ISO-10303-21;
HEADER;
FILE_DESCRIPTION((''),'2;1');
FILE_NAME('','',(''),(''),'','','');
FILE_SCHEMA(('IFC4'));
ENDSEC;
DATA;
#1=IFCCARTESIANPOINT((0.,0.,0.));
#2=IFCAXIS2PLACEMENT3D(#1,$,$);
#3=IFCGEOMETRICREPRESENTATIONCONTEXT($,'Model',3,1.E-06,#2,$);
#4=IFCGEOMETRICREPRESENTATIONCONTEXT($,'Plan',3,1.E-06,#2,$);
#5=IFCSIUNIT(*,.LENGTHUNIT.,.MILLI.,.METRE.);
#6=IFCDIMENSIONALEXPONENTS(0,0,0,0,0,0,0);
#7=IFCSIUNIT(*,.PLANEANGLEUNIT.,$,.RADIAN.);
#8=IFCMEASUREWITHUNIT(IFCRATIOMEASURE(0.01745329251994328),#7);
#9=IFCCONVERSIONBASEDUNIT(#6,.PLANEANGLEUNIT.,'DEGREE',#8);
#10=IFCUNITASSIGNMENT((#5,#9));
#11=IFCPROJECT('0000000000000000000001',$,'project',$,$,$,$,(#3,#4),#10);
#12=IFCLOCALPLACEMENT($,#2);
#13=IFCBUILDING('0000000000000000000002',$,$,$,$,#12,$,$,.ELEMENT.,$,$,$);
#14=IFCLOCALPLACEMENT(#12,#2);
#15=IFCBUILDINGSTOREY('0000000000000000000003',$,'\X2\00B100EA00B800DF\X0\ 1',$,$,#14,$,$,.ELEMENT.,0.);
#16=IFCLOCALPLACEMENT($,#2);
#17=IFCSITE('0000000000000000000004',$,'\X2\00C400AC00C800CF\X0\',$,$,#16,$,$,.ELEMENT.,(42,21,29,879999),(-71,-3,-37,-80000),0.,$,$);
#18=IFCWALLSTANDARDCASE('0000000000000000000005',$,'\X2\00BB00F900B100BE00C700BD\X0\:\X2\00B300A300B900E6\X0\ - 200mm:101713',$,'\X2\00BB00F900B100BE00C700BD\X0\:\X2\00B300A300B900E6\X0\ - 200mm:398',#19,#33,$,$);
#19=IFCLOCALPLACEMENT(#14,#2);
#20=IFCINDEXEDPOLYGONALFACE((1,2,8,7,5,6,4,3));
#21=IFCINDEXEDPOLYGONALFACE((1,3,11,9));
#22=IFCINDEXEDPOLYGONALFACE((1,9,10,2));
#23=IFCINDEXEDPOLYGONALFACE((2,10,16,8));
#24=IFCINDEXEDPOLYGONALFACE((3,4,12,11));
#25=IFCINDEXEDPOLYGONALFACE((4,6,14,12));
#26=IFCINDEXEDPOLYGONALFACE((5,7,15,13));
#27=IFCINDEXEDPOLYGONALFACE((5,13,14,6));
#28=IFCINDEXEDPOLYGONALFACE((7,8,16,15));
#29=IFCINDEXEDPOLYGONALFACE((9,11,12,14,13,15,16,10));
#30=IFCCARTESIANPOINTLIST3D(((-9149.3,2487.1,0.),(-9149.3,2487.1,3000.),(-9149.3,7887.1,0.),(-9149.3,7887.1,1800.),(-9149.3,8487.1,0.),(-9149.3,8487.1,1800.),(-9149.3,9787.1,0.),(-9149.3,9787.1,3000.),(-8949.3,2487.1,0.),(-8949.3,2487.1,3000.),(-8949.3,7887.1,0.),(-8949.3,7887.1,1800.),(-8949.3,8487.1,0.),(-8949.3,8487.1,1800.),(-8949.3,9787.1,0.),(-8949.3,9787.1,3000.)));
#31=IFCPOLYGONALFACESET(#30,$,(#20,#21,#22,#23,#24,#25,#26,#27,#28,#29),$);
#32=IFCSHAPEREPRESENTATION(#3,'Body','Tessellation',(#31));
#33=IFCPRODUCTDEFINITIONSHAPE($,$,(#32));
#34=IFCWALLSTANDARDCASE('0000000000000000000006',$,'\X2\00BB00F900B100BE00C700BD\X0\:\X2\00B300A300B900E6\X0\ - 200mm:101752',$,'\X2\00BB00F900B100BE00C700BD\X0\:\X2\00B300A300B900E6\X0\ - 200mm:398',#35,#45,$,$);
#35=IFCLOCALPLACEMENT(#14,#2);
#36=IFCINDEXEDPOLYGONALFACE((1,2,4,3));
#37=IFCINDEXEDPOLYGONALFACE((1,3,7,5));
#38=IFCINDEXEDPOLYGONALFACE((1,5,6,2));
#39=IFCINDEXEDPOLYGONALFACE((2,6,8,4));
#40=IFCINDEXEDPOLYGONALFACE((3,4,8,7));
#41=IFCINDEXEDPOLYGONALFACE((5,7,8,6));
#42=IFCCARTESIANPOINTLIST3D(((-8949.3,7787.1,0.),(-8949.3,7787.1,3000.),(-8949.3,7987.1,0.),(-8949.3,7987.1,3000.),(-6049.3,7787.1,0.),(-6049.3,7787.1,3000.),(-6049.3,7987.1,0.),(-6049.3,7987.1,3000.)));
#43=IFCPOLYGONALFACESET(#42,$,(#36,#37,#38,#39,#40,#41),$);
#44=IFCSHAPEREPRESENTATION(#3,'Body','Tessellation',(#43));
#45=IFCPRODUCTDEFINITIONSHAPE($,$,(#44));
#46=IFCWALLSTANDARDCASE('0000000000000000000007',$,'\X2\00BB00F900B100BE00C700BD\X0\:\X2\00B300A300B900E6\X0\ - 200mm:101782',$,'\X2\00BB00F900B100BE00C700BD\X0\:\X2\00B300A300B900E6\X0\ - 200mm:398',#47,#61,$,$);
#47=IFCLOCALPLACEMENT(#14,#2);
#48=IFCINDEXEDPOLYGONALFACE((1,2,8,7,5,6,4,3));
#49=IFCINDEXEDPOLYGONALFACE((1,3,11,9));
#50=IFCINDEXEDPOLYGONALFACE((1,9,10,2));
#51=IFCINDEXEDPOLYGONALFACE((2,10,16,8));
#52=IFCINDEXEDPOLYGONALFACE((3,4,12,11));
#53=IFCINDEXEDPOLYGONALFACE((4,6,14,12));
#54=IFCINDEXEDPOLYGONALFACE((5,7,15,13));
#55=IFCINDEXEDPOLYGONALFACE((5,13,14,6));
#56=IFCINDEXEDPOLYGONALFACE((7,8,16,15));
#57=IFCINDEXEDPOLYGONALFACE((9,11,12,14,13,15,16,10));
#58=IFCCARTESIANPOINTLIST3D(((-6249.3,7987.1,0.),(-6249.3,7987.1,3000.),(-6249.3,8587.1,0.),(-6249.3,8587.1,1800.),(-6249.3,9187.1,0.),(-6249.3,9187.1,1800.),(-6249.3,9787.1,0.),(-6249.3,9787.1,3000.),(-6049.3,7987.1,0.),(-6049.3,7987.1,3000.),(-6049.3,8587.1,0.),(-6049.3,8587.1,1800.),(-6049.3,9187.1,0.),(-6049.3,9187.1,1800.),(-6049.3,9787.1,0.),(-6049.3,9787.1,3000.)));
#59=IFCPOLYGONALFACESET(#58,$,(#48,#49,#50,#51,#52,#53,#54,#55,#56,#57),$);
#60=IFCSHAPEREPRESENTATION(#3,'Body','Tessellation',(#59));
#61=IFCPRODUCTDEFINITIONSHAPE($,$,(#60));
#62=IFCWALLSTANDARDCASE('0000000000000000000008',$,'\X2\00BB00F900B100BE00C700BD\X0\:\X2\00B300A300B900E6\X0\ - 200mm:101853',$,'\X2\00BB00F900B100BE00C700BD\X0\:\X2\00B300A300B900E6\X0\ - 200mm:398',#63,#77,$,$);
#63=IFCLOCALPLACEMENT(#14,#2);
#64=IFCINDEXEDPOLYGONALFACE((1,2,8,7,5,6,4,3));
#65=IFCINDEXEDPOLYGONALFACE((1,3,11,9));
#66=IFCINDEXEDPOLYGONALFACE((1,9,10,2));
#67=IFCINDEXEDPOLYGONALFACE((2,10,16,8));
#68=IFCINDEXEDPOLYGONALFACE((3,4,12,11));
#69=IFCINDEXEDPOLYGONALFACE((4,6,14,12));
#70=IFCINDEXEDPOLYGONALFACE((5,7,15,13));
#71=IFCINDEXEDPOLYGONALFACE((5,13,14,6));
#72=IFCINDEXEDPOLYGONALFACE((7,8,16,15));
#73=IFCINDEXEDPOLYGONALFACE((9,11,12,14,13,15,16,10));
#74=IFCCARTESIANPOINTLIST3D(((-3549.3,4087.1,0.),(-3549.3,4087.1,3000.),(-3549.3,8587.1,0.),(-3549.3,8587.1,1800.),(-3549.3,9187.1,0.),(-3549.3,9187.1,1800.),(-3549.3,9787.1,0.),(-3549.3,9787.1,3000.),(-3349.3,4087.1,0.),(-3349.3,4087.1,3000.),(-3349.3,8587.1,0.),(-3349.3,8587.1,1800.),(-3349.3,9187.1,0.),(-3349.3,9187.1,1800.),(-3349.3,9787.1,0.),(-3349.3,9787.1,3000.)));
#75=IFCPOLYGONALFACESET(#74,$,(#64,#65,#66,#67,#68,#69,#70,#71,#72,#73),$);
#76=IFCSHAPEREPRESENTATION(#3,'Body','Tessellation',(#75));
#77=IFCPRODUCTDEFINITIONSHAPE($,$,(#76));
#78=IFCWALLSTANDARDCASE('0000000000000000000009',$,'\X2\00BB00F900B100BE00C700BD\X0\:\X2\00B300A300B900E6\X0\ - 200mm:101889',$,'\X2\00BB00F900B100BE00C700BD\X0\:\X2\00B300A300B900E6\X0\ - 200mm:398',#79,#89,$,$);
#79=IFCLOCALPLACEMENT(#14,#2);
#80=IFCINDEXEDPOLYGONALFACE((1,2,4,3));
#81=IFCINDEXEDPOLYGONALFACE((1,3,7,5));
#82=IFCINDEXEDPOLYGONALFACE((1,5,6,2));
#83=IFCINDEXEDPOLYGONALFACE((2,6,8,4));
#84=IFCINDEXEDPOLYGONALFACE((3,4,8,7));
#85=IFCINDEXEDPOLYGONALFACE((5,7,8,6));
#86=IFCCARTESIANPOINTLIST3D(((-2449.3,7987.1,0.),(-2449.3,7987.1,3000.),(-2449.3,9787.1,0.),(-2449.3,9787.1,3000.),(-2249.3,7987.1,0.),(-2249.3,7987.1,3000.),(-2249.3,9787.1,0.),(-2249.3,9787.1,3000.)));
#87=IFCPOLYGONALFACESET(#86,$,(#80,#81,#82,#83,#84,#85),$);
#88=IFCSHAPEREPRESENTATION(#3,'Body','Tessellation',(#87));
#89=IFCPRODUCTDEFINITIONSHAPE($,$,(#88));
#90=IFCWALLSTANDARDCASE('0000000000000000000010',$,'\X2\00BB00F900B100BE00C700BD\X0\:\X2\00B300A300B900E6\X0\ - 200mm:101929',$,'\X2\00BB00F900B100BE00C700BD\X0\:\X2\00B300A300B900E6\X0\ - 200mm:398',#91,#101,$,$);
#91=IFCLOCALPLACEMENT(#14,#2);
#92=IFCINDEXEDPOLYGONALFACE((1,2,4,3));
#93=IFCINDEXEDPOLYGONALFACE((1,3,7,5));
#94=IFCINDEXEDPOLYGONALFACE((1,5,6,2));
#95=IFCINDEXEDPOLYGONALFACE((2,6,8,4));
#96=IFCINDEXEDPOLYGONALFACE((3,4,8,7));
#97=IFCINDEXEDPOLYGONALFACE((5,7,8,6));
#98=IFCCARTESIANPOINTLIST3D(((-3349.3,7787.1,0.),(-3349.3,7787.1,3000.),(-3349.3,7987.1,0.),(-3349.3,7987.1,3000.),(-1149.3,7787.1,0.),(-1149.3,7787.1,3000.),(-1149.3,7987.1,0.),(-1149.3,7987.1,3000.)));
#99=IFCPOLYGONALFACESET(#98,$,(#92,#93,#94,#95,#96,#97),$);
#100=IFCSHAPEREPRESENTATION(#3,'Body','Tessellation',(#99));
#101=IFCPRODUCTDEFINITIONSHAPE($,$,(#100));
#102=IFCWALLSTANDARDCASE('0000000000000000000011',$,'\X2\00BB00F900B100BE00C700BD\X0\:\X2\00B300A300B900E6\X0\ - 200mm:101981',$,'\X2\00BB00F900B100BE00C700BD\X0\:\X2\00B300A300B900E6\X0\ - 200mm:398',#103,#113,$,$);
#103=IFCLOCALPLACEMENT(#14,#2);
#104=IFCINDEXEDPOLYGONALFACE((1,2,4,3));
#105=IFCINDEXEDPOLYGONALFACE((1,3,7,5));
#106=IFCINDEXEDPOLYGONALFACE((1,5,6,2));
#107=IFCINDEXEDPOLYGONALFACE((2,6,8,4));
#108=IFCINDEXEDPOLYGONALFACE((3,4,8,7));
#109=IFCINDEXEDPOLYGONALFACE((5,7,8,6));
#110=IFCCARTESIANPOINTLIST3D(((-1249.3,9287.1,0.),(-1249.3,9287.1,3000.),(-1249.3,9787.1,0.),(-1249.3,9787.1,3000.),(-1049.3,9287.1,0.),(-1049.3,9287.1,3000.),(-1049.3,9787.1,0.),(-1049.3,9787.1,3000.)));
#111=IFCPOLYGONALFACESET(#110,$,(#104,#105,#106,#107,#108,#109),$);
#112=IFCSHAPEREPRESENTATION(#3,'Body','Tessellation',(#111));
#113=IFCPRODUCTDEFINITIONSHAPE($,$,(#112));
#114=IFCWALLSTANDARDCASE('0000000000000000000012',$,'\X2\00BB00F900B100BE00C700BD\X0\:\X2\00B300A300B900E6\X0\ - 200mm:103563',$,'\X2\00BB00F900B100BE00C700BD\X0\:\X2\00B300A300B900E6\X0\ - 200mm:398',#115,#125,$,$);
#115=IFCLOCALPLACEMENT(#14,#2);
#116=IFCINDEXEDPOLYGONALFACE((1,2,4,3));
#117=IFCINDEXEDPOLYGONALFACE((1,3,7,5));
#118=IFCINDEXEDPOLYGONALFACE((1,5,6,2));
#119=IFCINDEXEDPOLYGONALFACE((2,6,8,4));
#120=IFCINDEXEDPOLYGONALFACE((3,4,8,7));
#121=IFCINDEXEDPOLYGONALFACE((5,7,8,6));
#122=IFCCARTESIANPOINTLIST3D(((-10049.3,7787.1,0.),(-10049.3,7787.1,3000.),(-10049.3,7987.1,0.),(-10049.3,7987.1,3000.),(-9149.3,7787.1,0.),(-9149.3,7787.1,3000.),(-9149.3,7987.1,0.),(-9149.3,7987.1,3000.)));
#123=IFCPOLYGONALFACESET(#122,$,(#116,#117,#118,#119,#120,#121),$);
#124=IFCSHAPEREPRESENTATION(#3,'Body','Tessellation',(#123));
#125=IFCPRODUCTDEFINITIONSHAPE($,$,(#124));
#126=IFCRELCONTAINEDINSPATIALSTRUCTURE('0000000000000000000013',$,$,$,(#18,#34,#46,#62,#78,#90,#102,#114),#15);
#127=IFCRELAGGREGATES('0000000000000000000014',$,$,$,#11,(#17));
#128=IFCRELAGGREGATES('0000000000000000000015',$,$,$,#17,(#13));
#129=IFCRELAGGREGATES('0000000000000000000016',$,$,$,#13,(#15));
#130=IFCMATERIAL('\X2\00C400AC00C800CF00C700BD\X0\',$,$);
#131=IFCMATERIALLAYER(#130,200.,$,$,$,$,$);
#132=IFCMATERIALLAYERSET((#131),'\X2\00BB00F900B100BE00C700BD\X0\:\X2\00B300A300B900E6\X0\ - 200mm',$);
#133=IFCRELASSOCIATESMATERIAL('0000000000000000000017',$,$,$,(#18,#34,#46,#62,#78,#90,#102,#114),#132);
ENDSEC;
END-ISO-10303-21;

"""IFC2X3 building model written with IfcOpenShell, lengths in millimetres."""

from ifc_helpers import new_model, entity, si_unit, converted_unit, frame, frame_2d, origin, place, context, project, spatial, rectangle, extrude, material, layer, layer_set, layer_usage, element, save


model = new_model("IFC2X3")

# Units and contexts
model_context = context("Model", 3, precision=1e-06, world=origin())
plan_context = context("Plan", 3, precision=1e-06, world=origin())
ifc_project = project(units=[si_unit("LENGTHUNIT", "METRE", prefix="MILLI"), converted_unit("PLANEANGLEUNIT", "DEGREE", entity("IfcRatioMeasure", 0.01745329251994328), si_unit("PLANEANGLEUNIT", "RADIAN"), dimensions=[0, 0, 0, 0, 0, 0, 0])], contexts=[model_context, plan_context])

# Site, building, storey
site_placement = place(None, origin())
site = spatial("IfcSite", under=ifc_project, at=site_placement, Name="Ä¬ÈÏ", CompositionType="ELEMENT", RefLatitude=(42, 21, 29, 879999), RefLongitude=(-71, -3, -37, -80000), RefElevation=0.0)
building_placement = place(None, origin())
building = spatial("IfcBuilding", under=site, at=building_placement, CompositionType="ELEMENT")
storey_placement = place(building_placement, origin())
storey = spatial("IfcBuildingStorey", under=building, at=storey_placement, Name="±ê¸ß 1", CompositionType="ELEMENT", Elevation=0.0)

# Shared definitions
ifc_material = material(Name="Ä¬ÈÏÇ½")
ifc_layer = layer(ifc_material, 200.0)
ifc_layer_set = layer_set([ifc_layer], Name="»ù±¾Ç½:³£¹æ - 200mm")

# Wall, opening
ifc_layer_usage_1 = layer_usage(ifc_layer_set, "AXIS2", "NEGATIVE", 100.0)
wall_1_placement = place(storey_placement, frame((-9049.3, 9787.1, 0.0), z_axis=(0.0, 0.0, 1.0), x_axis=(0.0, -1.0, 0.0)))
wall_1 = element("IfcWallStandardCase", 1, at=wall_1_placement, inside=storey, material=ifc_layer_usage_1, Name="»ù±¾Ç½:³£¹æ - 200mm:101713", ObjectType="»ù±¾Ç½:³£¹æ - 200mm:398", context=model_context, shape_type="SweptSolid", body=[
    extrude(rectangle(XDim=7300.0, YDim=200.0, at=frame_2d((3650.0, 0.0), x_axis=(-1.0, 0.0))), origin(), (0.0, 0.0, 1.0), 3000.0),
])
opening_1_placement = place(wall_1_placement, frame((1900.0, 100.0, 0.0)))
element("IfcOpeningElement", 2, at=opening_1_placement, cuts=wall_1, ObjectType="Opening", context=model_context, shape_type="SweptSolid", body=[
    extrude(rectangle(XDim=1800.0, YDim=600.0, at=frame_2d((900.0, 300.0), x_axis=(1.0, 0.0))), frame((0.0, 0.0, 0.0), z_axis=(0.0, -1.0, 0.0), x_axis=(0.0, 0.0, 1.0)), (0.0, 0.0, 1.0), 200.0),
])

# Wall
ifc_layer_usage_2 = layer_usage(ifc_layer_set, "AXIS2", "NEGATIVE", 100.0)
wall_2_placement = place(storey_placement, frame((-8949.3, 7887.1, 0.0)))
element("IfcWallStandardCase", 3, at=wall_2_placement, inside=storey, material=ifc_layer_usage_2, Name="»ù±¾Ç½:³£¹æ - 200mm:101752", ObjectType="»ù±¾Ç½:³£¹æ - 200mm:398", context=model_context, shape_type="SweptSolid", body=[
    extrude(rectangle(XDim=2900.0, YDim=200.0, at=frame_2d((1450.0, 0.0), x_axis=(-1.0, 0.0))), origin(), (0.0, 0.0, 1.0), 3000.0),
])

# Walls, openings
ifc_layer_usage_3 = layer_usage(ifc_layer_set, "AXIS2", "NEGATIVE", 100.0)
wall_3_placement = place(storey_placement, frame((-6149.3, 7987.1, 0.0), z_axis=(0.0, 0.0, 1.0), x_axis=(0.0, 1.0, 0.0)))
wall_3 = element("IfcWallStandardCase", 4, at=wall_3_placement, inside=storey, material=ifc_layer_usage_3, Name="»ù±¾Ç½:³£¹æ - 200mm:101782", ObjectType="»ù±¾Ç½:³£¹æ - 200mm:398", context=model_context, shape_type="SweptSolid", body=[
    extrude(rectangle(XDim=1800.0, YDim=200.0, at=frame_2d((900.0, 0.0), x_axis=(-1.0, 0.0))), origin(), (0.0, 0.0, 1.0), 3000.0),
])
opening_2_placement = place(wall_3_placement, frame((600.0, -100.0, 0.0)))
element("IfcOpeningElement", 5, at=opening_2_placement, cuts=wall_3, ObjectType="Opening", context=model_context, shape_type="SweptSolid", body=[
    extrude(rectangle(XDim=1800.0, YDim=600.0, at=frame_2d((900.0, 300.0), x_axis=(1.0, 0.0))), frame((0.0, 0.0, 0.0), z_axis=(0.0, 1.0, 0.0), x_axis=(0.0, 0.0, 1.0)), (0.0, 0.0, 1.0), 200.0),
])
ifc_layer_usage_4 = layer_usage(ifc_layer_set, "AXIS2", "NEGATIVE", 100.0)
wall_4_placement = place(storey_placement, frame((-3449.3, 4087.1, 0.0), z_axis=(0.0, 0.0, 1.0), x_axis=(0.0, 1.0, 0.0)))
wall_4 = element("IfcWallStandardCase", 6, at=wall_4_placement, inside=storey, material=ifc_layer_usage_4, Name="»ù±¾Ç½:³£¹æ - 200mm:101853", ObjectType="»ù±¾Ç½:³£¹æ - 200mm:398", context=model_context, shape_type="SweptSolid", body=[
    extrude(rectangle(XDim=5700.0, YDim=200.0, at=frame_2d((2850.0, 0.0), x_axis=(-1.0, 0.0))), origin(), (0.0, 0.0, 1.0), 3000.0),
])
opening_3_placement = place(wall_4_placement, frame((5100.0, 100.0, 0.0)))
element("IfcOpeningElement", 7, at=opening_3_placement, cuts=wall_4, ObjectType="Opening", context=model_context, shape_type="SweptSolid", body=[
    extrude(rectangle(XDim=1800.0, YDim=600.0, at=frame_2d((900.0, 300.0), x_axis=(1.0, 0.0))), frame((0.0, 0.0, 0.0), z_axis=(0.0, -1.0, 0.0), x_axis=(0.0, 0.0, 1.0)), (0.0, 0.0, 1.0), 200.0),
])

# Walls
ifc_layer_usage_5 = layer_usage(ifc_layer_set, "AXIS2", "NEGATIVE", 100.0)
wall_5_placement = place(storey_placement, frame((-2349.3, 9787.1, 0.0), z_axis=(0.0, 0.0, 1.0), x_axis=(0.0, -1.0, 0.0)))
element("IfcWallStandardCase", 8, at=wall_5_placement, inside=storey, material=ifc_layer_usage_5, Name="»ù±¾Ç½:³£¹æ - 200mm:101889", ObjectType="»ù±¾Ç½:³£¹æ - 200mm:398", context=model_context, shape_type="SweptSolid", body=[
    extrude(rectangle(XDim=1800.0, YDim=200.0, at=frame_2d((900.0, 0.0), x_axis=(-1.0, 0.0))), origin(), (0.0, 0.0, 1.0), 3000.0),
])
ifc_layer_usage_6 = layer_usage(ifc_layer_set, "AXIS2", "NEGATIVE", 100.0)
wall_6_placement = place(storey_placement, frame((-3349.3, 7887.1, 0.0)))
element("IfcWallStandardCase", 9, at=wall_6_placement, inside=storey, material=ifc_layer_usage_6, Name="»ù±¾Ç½:³£¹æ - 200mm:101929", ObjectType="»ù±¾Ç½:³£¹æ - 200mm:398", context=model_context, shape_type="SweptSolid", body=[
    extrude(rectangle(XDim=2200.0, YDim=200.0, at=frame_2d((1100.0, 0.0), x_axis=(-1.0, 0.0))), origin(), (0.0, 0.0, 1.0), 3000.0),
])
ifc_layer_usage_7 = layer_usage(ifc_layer_set, "AXIS2", "NEGATIVE", 100.0)
wall_7_placement = place(storey_placement, frame((-1149.3, 9787.1, 0.0), z_axis=(0.0, 0.0, 1.0), x_axis=(0.0, -1.0, 0.0)))
element("IfcWallStandardCase", 10, at=wall_7_placement, inside=storey, material=ifc_layer_usage_7, Name="»ù±¾Ç½:³£¹æ - 200mm:101981", ObjectType="»ù±¾Ç½:³£¹æ - 200mm:398", context=model_context, shape_type="SweptSolid", body=[
    extrude(rectangle(XDim=500.0, YDim=200.0, at=frame_2d((250.0, 0.0), x_axis=(-1.0, 0.0))), origin(), (0.0, 0.0, 1.0), 3000.0),
])
ifc_layer_usage_8 = layer_usage(ifc_layer_set, "AXIS2", "NEGATIVE", 100.0)
wall_8_placement = place(storey_placement, frame((-10049.3, 7887.1, 0.0)))
element("IfcWallStandardCase", 11, at=wall_8_placement, inside=storey, material=ifc_layer_usage_8, Name="»ù±¾Ç½:³£¹æ - 200mm:103563", ObjectType="»ù±¾Ç½:³£¹æ - 200mm:398", context=model_context, shape_type="SweptSolid", body=[
    extrude(rectangle(XDim=900.0, YDim=200.0, at=frame_2d((450.0, 0.0), x_axis=(-1.0, 0.0))), origin(), (0.0, 0.0, 1.0), 3000.0),
])

save(model, "model.ifc")
